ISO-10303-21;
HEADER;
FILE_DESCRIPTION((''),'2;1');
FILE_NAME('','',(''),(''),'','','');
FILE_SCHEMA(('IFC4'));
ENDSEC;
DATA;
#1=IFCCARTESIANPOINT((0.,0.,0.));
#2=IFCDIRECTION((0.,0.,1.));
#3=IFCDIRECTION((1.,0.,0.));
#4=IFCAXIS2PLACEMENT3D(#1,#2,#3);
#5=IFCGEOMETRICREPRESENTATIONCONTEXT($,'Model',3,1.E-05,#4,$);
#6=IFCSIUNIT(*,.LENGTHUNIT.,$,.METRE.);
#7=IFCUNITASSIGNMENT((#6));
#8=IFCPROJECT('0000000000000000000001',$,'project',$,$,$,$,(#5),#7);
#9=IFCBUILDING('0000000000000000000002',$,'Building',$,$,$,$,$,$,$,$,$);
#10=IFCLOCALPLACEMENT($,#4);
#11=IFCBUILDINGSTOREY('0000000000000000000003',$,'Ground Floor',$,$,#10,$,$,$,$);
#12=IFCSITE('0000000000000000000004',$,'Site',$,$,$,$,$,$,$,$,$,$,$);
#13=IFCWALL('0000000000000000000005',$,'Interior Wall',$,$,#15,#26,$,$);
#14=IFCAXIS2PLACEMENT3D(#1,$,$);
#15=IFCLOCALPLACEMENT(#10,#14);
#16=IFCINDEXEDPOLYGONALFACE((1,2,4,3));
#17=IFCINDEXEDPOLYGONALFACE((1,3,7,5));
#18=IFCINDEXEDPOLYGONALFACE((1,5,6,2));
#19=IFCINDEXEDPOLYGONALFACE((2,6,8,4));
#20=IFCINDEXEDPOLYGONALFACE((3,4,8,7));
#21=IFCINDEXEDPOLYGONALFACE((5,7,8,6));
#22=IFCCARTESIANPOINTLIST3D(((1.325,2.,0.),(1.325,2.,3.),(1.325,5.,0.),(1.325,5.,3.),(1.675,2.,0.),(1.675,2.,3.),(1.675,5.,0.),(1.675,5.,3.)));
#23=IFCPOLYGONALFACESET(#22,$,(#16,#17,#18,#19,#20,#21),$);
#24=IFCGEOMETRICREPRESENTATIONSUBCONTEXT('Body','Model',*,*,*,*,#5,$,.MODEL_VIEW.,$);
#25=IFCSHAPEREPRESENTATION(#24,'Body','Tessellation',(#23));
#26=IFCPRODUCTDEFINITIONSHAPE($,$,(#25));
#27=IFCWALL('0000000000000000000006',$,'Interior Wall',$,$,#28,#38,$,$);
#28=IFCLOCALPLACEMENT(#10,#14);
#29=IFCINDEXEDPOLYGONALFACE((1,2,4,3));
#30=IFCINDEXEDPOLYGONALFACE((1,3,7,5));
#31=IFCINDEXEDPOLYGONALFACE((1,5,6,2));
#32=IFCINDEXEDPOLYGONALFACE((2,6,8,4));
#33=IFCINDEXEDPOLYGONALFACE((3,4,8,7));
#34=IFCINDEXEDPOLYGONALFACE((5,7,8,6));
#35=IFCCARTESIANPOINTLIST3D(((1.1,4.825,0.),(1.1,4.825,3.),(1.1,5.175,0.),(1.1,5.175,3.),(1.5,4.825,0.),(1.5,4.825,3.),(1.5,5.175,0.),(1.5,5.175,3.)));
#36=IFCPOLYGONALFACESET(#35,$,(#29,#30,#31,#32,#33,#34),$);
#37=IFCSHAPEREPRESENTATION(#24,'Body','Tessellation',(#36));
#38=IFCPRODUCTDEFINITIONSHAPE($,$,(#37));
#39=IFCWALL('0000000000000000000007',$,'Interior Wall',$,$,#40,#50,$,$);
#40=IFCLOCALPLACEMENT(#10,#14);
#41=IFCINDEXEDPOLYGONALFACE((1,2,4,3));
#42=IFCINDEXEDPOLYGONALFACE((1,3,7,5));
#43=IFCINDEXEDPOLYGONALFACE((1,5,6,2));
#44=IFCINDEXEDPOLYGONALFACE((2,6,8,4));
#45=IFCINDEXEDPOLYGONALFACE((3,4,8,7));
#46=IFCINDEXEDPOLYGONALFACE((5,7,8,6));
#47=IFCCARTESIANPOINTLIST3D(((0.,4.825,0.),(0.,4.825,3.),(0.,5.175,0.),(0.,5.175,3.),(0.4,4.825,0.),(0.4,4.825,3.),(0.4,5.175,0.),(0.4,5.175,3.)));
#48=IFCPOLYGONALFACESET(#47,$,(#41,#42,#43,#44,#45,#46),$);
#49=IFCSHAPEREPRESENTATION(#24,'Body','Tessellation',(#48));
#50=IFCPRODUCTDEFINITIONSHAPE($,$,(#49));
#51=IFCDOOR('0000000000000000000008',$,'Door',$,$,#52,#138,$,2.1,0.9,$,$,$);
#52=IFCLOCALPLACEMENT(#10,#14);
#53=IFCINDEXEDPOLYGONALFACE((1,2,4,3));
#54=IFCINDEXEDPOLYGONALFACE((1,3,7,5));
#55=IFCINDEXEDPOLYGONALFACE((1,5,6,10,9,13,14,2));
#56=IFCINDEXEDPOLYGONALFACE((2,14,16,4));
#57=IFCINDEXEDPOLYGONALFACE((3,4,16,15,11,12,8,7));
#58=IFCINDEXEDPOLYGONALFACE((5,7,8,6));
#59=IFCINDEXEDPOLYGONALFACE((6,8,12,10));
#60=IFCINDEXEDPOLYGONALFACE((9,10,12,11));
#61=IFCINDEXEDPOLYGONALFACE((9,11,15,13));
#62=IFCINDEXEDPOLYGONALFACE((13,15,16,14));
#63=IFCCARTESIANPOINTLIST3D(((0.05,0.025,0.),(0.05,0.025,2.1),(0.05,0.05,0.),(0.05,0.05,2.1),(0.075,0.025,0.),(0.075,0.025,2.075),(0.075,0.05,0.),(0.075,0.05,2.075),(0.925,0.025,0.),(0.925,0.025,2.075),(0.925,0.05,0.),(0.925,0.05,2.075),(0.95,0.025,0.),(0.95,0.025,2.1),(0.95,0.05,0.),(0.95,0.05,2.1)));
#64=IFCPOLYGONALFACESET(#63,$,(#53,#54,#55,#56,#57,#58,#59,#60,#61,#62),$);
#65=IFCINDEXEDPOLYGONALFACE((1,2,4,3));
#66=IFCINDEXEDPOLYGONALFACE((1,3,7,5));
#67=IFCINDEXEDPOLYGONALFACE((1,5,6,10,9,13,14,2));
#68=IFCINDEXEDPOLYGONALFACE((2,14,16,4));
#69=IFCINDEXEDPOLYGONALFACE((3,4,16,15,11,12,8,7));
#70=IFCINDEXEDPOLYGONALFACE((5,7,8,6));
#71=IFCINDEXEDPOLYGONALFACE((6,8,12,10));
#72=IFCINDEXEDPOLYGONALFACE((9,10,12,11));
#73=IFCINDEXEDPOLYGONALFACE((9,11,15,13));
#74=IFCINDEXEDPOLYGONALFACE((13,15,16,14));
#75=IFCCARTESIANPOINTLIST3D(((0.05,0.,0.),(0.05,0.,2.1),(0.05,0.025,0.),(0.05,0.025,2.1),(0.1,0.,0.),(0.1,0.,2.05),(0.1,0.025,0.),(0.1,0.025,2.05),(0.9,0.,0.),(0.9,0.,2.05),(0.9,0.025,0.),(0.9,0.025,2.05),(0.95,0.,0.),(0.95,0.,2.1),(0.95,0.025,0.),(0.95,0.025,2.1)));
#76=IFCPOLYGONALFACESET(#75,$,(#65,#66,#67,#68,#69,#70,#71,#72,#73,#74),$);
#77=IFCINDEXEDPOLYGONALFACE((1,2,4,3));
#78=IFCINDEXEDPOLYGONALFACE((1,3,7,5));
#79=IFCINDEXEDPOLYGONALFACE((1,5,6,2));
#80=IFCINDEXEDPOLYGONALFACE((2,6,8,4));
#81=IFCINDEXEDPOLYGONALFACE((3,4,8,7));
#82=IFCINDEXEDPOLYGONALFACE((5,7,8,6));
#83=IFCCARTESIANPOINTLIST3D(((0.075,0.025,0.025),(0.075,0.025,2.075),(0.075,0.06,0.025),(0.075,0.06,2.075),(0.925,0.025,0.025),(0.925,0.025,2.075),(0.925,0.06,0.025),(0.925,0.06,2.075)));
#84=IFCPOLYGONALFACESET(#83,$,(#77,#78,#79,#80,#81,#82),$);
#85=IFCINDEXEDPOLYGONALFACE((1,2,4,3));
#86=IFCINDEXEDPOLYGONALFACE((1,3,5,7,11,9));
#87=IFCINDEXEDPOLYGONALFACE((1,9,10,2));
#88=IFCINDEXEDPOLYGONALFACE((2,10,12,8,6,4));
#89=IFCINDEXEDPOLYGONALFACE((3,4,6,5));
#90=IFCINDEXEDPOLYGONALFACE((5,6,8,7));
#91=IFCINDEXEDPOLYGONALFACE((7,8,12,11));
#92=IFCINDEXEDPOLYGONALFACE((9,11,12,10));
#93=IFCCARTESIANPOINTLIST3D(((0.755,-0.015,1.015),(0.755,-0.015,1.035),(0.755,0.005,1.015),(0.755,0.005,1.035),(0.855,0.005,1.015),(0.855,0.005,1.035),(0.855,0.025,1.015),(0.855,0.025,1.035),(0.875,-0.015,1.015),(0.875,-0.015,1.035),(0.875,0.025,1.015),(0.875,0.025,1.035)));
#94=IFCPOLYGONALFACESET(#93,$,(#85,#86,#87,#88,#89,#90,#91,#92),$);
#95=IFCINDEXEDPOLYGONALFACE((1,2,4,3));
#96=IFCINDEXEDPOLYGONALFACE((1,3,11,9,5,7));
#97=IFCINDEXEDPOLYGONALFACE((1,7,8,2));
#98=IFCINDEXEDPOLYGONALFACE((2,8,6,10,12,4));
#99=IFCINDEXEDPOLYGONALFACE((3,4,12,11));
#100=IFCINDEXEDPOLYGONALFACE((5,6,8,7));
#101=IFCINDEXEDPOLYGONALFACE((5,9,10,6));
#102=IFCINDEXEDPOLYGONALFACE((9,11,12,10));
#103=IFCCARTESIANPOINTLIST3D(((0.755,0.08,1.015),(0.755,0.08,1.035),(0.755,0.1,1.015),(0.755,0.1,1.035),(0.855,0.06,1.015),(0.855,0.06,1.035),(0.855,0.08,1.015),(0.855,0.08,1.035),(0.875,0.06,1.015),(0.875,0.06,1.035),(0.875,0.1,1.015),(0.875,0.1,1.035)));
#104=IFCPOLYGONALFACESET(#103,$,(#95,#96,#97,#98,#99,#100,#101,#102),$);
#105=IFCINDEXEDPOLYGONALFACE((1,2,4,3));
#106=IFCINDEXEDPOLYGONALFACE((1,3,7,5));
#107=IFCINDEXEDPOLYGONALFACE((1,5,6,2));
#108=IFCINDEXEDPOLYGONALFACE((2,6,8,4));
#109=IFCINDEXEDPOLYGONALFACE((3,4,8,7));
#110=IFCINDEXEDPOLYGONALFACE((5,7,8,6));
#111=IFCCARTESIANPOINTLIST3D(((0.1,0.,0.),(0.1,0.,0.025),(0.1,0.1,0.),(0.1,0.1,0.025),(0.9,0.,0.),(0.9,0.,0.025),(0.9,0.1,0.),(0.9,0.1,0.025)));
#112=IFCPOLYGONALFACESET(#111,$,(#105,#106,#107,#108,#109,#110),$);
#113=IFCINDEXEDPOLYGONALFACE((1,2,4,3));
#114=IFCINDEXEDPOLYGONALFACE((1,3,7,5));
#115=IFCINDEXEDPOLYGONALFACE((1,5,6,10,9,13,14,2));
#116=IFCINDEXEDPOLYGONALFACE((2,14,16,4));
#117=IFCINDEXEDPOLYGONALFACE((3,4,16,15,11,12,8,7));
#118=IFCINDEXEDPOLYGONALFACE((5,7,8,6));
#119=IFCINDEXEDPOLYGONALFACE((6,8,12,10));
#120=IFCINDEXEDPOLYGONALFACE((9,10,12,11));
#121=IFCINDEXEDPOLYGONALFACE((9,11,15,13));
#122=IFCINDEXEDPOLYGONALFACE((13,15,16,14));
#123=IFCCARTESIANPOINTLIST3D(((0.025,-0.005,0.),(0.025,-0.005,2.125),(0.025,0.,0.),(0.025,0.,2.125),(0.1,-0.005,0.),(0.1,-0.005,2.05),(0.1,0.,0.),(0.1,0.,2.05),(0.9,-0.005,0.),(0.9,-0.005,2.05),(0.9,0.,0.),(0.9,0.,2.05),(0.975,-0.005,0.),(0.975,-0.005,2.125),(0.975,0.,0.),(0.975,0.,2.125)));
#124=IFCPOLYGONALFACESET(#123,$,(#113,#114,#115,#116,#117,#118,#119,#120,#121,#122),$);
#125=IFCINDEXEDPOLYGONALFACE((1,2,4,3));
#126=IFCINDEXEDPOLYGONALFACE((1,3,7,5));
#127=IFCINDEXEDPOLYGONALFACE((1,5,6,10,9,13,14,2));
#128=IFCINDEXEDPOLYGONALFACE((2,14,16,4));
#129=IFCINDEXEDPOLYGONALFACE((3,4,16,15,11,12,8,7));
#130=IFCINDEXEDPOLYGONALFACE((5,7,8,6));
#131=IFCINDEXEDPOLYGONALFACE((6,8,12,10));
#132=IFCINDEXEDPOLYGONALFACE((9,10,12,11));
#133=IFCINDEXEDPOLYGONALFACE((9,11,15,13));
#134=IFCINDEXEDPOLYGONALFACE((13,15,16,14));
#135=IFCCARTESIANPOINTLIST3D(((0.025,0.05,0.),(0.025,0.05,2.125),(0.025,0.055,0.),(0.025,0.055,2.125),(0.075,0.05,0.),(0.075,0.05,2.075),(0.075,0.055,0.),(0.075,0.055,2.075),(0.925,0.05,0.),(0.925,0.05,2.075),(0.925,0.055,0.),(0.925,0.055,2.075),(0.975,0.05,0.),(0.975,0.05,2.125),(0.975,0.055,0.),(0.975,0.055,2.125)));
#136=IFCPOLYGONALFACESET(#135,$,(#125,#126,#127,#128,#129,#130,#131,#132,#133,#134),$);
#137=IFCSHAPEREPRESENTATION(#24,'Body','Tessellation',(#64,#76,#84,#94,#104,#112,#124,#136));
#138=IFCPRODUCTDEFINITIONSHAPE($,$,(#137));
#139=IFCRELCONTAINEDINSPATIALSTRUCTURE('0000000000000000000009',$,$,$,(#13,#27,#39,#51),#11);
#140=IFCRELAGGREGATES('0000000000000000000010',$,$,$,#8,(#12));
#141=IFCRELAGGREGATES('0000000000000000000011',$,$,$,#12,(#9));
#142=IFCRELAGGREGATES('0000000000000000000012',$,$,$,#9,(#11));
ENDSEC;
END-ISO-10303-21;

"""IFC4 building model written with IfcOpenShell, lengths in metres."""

from ifc_helpers import new_model, si_unit, frame, origin_with_axes, place, context, subcontext, project, spatial, line, indexed_curve, outline, extrude, element, save


model = new_model("IFC4")

# Units and contexts
model_context = context("Model", 3, precision=1e-05, world=origin_with_axes())
body_context = subcontext(model_context, "Body", "Model", "MODEL_VIEW")
ifc_project = project(units=[si_unit("LENGTHUNIT", "METRE")], contexts=[model_context])

# Site, building, storey
site = spatial("IfcSite", under=ifc_project, Name="Site")
building = spatial("IfcBuilding", under=site, Name="Building")
storey_placement = place(None, origin_with_axes())
storey = spatial("IfcBuildingStorey", under=building, at=storey_placement, Name="Ground Floor")

# Walls
wall_1_placement = place(storey_placement, frame((1.5, 5.0, 0.0), z_axis=(0.0, 0.0, 1.0), x_axis=(0.0, -1.0, 0.0)))
element("IfcWall", 1, at=wall_1_placement, inside=storey, Name="Interior Wall", context=body_context, shape_type="SweptSolid", body=[
    extrude(outline(indexed_curve([(0.0, 0.0), (0.0, 0.35), (3.0, 0.35), (3.0, 0.0), (0.0, 0.0)], self_intersect=False)), frame((0.0, -0.175, 0.0), z_axis=(0.0, 0.0, 1.0), x_axis=(1.0, 0.0, 0.0)), (0.0, 0.0, 1.0), 3.0),
])
for number, where, z_axis, x_axis, name in (
    (2, (1.5, 5.0, 0.0), (0.0, 0.0, 1.0), (-1.0, 0.0, 0.0), "Interior Wall"),
    (3, (0.4, 5.0, 0.0), (0.0, 0.0, 1.0), (-1.0, 0.0, 0.0), "Interior Wall"),
):
    element("IfcWall", number, at=place(storey_placement, frame(where, z_axis=z_axis, x_axis=x_axis)), inside=storey, Name=name, context=body_context, shape_type="SweptSolid", body=[
        extrude(outline(indexed_curve([(0.0, 0.0), (0.0, 0.35), (0.4, 0.35), (0.4, 0.0), (0.0, 0.0)], self_intersect=False)), frame((0.0, -0.175, 0.0), z_axis=(0.0, 0.0, 1.0), x_axis=(1.0, 0.0, 0.0)), (0.0, 0.0, 1.0), 3.0),
    ])

# Door
door_1_placement = place(storey_placement, frame((0.05, 0.0, 0.0), z_axis=(0.0, 0.0, 1.0), x_axis=(1.0, 0.0, 0.0)))
element("IfcDoor", 4, at=door_1_placement, inside=storey, Name="Door", OverallHeight=2.1, OverallWidth=0.9, context=body_context, shape_type="SweptSolid", body=[
    extrude(outline(indexed_curve([(0.0, 0.0), (0.0, 2.1), (0.9, 2.1), (0.9, 0.0), (0.875, 0.0), (0.875, 2.075), (0.025, 2.075), (0.025, 0.0)], segments=[line(1, 2, 3, 4, 5, 6, 7, 8, 1)])), frame((0.0, 0.025, 0.0), z_axis=(0.0, -1.0, 0.0), x_axis=(1.0, 0.0, 0.0)), (0.0, 0.0, -1.0), 0.025),
    extrude(outline(indexed_curve([(0.0, 0.0), (0.0, 2.1), (0.9, 2.1), (0.9, 0.0), (0.85, 0.0), (0.85, 2.05), (0.05, 2.05), (0.05, 0.0)], segments=[line(1, 2, 3, 4, 5, 6, 7, 8, 1)])), frame((0.0, 0.0, 0.0), z_axis=(0.0, -1.0, 0.0), x_axis=(1.0, 0.0, 0.0)), (0.0, 0.0, -1.0), 0.025),
    extrude(outline(indexed_curve([(0.0, 0.0), (0.85, 0.0), (0.85, 0.035), (0.0, 0.035)], segments=[line(1, 2, 3, 4, 1)])), frame((0.025, 0.025, 0.025), z_axis=(0.0, 0.0, 1.0), x_axis=(1.0, 0.0, 0.0)), (0.0, 0.0, 1.0), 2.05),
    extrude(outline(indexed_curve([(0.0, 0.0), (0.0, -0.04), (-0.12, -0.04), (-0.12, -0.02), (-0.02, -0.02), (-0.02, 0.0)], segments=[line(1, 2, 3, 4, 5, 6, 1)])), frame((0.825, 0.025, 1.015), z_axis=(0.0, 0.0, 1.0), x_axis=(1.0, 0.0, 0.0)), (0.0, 0.0, 1.0), 0.02),
    extrude(outline(indexed_curve([(0.0, 0.0), (0.0, 0.04), (-0.12, 0.04), (-0.12, 0.02), (-0.02, 0.02), (-0.02, 0.0)], segments=[line(1, 2, 3, 4, 5, 6, 1)])), frame((0.825, 0.06, 1.015), z_axis=(0.0, 0.0, 1.0), x_axis=(1.0, 0.0, 0.0)), (0.0, 0.0, 1.0), 0.02),
    extrude(outline(indexed_curve([(0.0, 0.0), (0.8, 0.0), (0.8, 0.1), (0.0, 0.1)], segments=[line(1, 2, 3, 4, 1)])), frame((0.05, 0.0, 0.0), z_axis=(0.0, 0.0, 1.0), x_axis=(1.0, 0.0, 0.0)), (0.0, 0.0, 1.0), 0.025),
    extrude(outline(indexed_curve([(0.0, 0.0), (0.0, 2.125), (0.95, 2.125), (0.95, 0.0), (0.875, 0.0), (0.875, 2.05), (0.075, 2.05), (0.075, 0.0)], segments=[line(1, 2, 3, 4, 5, 6, 7, 8, 1)])), frame((-0.025, -0.005, 0.0), z_axis=(0.0, -1.0, 0.0), x_axis=(1.0, 0.0, 0.0)), (0.0, 0.0, -1.0), 0.005),
    extrude(outline(indexed_curve([(0.0, 0.0), (0.0, 2.125), (0.95, 2.125), (0.95, 0.0), (0.9, 0.0), (0.9, 2.075), (0.05, 2.075), (0.05, 0.0)], segments=[line(1, 2, 3, 4, 5, 6, 7, 8, 1)])), frame((-0.025, 0.05, 0.0), z_axis=(0.0, -1.0, 0.0), x_axis=(1.0, 0.0, 0.0)), (0.0, 0.0, -1.0), 0.005),
])

save(model, "model.ifc")
